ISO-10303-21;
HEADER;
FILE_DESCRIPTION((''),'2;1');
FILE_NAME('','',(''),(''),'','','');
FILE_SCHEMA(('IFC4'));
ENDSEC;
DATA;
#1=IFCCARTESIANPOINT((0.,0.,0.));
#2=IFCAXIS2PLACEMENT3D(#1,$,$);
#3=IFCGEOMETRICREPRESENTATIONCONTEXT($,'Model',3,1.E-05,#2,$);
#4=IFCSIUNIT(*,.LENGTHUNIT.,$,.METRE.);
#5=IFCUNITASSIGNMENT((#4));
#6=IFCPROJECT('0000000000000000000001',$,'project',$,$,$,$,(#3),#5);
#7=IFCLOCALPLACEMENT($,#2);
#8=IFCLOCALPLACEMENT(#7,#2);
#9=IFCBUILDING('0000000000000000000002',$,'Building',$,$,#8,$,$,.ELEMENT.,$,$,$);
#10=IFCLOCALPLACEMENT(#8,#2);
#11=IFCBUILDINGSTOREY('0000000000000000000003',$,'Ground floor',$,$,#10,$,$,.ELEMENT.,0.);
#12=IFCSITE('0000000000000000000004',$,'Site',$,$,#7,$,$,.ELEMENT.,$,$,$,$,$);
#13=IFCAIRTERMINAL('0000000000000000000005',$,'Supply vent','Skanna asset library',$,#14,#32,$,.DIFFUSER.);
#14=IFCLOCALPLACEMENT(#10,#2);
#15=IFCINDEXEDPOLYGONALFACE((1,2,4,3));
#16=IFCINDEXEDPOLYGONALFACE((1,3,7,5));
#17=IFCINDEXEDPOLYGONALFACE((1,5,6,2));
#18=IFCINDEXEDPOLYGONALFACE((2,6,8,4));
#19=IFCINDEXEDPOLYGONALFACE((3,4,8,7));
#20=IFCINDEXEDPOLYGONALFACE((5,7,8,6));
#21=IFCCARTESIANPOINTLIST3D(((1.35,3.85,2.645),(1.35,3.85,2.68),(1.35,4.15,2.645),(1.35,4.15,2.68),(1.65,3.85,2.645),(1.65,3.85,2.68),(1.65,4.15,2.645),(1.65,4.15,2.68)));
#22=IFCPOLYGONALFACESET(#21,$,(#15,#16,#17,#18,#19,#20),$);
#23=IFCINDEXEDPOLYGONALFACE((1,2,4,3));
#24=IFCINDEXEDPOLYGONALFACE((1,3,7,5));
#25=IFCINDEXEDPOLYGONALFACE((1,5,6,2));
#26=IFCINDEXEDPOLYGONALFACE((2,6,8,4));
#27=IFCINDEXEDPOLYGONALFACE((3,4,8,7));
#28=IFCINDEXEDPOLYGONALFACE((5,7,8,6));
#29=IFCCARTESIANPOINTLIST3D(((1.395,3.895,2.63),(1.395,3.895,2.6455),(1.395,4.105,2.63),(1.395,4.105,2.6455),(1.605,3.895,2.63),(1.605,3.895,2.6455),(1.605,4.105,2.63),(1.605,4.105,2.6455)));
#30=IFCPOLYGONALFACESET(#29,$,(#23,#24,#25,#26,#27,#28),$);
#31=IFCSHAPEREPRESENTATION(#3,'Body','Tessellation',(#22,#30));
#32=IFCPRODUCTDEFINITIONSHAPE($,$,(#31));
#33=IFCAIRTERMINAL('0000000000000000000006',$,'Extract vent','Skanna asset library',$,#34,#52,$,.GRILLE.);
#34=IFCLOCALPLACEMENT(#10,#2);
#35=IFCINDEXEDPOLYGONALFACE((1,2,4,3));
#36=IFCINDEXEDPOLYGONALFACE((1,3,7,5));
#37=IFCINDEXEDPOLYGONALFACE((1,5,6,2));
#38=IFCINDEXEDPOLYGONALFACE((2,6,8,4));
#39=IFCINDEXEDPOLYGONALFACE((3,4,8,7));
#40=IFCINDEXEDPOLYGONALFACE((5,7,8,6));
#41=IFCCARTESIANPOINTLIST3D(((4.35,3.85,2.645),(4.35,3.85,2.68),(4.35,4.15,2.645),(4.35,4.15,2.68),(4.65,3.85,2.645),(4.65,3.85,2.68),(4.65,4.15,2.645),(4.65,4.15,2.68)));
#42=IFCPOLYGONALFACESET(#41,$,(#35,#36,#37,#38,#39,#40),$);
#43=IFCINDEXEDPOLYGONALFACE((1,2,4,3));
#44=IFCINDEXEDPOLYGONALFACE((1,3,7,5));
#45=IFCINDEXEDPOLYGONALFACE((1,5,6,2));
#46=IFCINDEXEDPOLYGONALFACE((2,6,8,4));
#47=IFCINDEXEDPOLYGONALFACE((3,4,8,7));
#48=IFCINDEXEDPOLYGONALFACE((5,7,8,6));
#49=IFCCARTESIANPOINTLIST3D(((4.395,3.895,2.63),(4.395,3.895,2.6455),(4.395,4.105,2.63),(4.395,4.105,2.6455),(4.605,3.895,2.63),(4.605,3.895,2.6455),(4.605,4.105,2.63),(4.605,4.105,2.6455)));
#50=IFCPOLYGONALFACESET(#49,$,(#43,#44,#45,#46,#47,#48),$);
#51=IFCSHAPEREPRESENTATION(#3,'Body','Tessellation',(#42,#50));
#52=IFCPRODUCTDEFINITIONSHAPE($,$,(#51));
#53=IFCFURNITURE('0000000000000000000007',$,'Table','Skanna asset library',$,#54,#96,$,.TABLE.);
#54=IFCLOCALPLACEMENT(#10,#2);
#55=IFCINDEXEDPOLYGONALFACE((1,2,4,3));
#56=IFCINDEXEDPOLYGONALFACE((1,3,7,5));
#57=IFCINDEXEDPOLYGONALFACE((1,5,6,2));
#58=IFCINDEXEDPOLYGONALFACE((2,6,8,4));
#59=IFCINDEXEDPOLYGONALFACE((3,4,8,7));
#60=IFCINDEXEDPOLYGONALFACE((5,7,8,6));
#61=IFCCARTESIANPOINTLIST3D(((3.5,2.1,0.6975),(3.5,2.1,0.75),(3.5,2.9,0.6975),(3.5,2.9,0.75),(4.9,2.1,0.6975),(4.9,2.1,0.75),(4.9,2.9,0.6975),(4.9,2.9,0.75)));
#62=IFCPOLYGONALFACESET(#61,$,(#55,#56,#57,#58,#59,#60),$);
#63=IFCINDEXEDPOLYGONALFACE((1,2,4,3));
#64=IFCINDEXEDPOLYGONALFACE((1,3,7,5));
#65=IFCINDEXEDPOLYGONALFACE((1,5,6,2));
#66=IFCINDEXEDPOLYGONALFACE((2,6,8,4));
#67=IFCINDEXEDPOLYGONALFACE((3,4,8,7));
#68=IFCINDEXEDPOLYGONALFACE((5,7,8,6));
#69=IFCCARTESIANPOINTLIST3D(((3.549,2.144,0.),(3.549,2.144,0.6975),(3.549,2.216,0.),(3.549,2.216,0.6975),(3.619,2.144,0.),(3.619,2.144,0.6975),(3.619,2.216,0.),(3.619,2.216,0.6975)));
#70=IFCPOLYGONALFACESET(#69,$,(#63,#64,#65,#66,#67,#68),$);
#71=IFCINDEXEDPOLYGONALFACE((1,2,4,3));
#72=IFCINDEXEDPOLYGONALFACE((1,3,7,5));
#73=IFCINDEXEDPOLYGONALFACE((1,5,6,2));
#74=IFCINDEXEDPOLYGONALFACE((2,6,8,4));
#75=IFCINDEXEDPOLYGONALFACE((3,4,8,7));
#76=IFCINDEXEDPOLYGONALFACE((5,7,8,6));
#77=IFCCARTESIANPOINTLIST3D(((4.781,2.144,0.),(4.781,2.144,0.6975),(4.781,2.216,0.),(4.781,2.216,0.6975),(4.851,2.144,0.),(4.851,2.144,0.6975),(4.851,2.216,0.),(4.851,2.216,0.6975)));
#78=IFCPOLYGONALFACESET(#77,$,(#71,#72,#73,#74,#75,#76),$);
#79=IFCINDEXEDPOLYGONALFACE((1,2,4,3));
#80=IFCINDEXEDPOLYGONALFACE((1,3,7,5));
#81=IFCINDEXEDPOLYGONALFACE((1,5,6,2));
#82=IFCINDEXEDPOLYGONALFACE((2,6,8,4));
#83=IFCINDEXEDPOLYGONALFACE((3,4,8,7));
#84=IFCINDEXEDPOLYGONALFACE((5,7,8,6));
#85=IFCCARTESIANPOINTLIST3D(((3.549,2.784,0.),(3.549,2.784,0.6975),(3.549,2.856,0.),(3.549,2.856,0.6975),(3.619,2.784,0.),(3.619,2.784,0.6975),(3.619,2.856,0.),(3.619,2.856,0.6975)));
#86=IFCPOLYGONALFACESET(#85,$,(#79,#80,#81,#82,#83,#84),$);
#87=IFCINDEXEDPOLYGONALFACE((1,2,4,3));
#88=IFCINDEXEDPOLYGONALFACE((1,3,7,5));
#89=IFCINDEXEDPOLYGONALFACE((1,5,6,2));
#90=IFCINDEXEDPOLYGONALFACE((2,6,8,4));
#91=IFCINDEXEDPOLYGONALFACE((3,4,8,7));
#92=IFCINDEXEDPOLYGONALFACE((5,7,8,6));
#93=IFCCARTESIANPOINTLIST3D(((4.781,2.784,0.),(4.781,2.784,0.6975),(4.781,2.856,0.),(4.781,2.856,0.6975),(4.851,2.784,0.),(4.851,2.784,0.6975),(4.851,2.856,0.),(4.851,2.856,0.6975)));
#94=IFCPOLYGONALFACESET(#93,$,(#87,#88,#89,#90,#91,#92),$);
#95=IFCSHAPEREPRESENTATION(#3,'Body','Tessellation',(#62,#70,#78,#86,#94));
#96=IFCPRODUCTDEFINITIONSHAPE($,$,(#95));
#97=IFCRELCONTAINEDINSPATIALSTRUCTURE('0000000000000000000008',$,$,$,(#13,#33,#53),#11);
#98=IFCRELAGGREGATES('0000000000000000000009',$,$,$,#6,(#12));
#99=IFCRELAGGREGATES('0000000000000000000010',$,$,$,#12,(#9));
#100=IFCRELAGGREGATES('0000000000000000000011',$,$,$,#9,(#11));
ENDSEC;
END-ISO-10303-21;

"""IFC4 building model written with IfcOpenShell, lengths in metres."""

from ifc_helpers import new_model, si_unit, frame, frame_2d, origin, origin_2d, place, context, project, spatial, rectangle, extrude, element, save


model = new_model("IFC4")

# Units and contexts
model_context = context("Model", 3, precision=1e-05, world=origin())
ifc_project = project(units=[si_unit("LENGTHUNIT", "METRE")], contexts=[model_context])

# Site, building, storey
site_placement = place(None, origin())
site = spatial("IfcSite", under=ifc_project, at=site_placement, Name="Site", CompositionType="ELEMENT")
building_placement = place(site_placement, origin())
building = spatial("IfcBuilding", under=site, at=building_placement, Name="Building", CompositionType="ELEMENT")
storey_placement = place(building_placement, origin())
storey = spatial("IfcBuildingStorey", under=building, at=storey_placement, Name="Ground floor", CompositionType="ELEMENT", Elevation=0.0)

# Air terminals
air_terminal_1_placement = place(storey_placement, frame((1.5, 4.0, 2.63), z_axis=(0.0, 0.0, 1.0), x_axis=(1.0, 0.0, 0.0)))
element("IfcAirTerminal", 1, at=air_terminal_1_placement, inside=storey, Name="Supply vent", Description="Skanna asset library", PredefinedType="DIFFUSER", context=model_context, shape_type="SweptSolid", body=[
    extrude(rectangle(XDim=0.3, YDim=0.3, at=origin_2d()), frame((0.0, 0.0, 0.015)), (0.0, 0.0, 1.0), 0.035),
    extrude(rectangle(XDim=0.21, YDim=0.21, at=origin_2d()), origin(), (0.0, 0.0, 1.0), 0.0155),
])
air_terminal_2_placement = place(storey_placement, frame((4.5, 4.0, 2.63), z_axis=(0.0, 0.0, 1.0), x_axis=(1.0, 0.0, 0.0)))
element("IfcAirTerminal", 2, at=air_terminal_2_placement, inside=storey, Name="Extract vent", Description="Skanna asset library", PredefinedType="GRILLE", context=model_context, shape_type="SweptSolid", body=[
    extrude(rectangle(XDim=0.3, YDim=0.3, at=origin_2d()), frame((0.0, 0.0, 0.015)), (0.0, 0.0, 1.0), 0.035),
    extrude(rectangle(XDim=0.21, YDim=0.21, at=origin_2d()), origin(), (0.0, 0.0, 1.0), 0.0155),
])

# Furniture
furniture_placement = place(storey_placement, frame((4.2, 2.5, 0.0), z_axis=(0.0, 0.0, 1.0), x_axis=(1.0, 0.0, 0.0)))
element("IfcFurniture", 3, at=furniture_placement, inside=storey, Name="Table", Description="Skanna asset library", PredefinedType="TABLE", context=model_context, shape_type="SweptSolid", body=[
    extrude(rectangle(XDim=1.4, YDim=0.8, at=origin_2d()), frame((0.0, 0.0, 0.6975)), (0.0, 0.0, 1.0), 0.0525),
    extrude(rectangle(XDim=0.07, YDim=0.072, at=frame_2d((-0.616, -0.32))), origin(), (0.0, 0.0, 1.0), 0.6975),
    extrude(rectangle(XDim=0.07, YDim=0.072, at=frame_2d((0.616, -0.32))), origin(), (0.0, 0.0, 1.0), 0.6975),
    extrude(rectangle(XDim=0.07, YDim=0.072, at=frame_2d((-0.616, 0.32))), origin(), (0.0, 0.0, 1.0), 0.6975),
    extrude(rectangle(XDim=0.07, YDim=0.072, at=frame_2d((0.616, 0.32))), origin(), (0.0, 0.0, 1.0), 0.6975),
])

save(model, "model.ifc")
